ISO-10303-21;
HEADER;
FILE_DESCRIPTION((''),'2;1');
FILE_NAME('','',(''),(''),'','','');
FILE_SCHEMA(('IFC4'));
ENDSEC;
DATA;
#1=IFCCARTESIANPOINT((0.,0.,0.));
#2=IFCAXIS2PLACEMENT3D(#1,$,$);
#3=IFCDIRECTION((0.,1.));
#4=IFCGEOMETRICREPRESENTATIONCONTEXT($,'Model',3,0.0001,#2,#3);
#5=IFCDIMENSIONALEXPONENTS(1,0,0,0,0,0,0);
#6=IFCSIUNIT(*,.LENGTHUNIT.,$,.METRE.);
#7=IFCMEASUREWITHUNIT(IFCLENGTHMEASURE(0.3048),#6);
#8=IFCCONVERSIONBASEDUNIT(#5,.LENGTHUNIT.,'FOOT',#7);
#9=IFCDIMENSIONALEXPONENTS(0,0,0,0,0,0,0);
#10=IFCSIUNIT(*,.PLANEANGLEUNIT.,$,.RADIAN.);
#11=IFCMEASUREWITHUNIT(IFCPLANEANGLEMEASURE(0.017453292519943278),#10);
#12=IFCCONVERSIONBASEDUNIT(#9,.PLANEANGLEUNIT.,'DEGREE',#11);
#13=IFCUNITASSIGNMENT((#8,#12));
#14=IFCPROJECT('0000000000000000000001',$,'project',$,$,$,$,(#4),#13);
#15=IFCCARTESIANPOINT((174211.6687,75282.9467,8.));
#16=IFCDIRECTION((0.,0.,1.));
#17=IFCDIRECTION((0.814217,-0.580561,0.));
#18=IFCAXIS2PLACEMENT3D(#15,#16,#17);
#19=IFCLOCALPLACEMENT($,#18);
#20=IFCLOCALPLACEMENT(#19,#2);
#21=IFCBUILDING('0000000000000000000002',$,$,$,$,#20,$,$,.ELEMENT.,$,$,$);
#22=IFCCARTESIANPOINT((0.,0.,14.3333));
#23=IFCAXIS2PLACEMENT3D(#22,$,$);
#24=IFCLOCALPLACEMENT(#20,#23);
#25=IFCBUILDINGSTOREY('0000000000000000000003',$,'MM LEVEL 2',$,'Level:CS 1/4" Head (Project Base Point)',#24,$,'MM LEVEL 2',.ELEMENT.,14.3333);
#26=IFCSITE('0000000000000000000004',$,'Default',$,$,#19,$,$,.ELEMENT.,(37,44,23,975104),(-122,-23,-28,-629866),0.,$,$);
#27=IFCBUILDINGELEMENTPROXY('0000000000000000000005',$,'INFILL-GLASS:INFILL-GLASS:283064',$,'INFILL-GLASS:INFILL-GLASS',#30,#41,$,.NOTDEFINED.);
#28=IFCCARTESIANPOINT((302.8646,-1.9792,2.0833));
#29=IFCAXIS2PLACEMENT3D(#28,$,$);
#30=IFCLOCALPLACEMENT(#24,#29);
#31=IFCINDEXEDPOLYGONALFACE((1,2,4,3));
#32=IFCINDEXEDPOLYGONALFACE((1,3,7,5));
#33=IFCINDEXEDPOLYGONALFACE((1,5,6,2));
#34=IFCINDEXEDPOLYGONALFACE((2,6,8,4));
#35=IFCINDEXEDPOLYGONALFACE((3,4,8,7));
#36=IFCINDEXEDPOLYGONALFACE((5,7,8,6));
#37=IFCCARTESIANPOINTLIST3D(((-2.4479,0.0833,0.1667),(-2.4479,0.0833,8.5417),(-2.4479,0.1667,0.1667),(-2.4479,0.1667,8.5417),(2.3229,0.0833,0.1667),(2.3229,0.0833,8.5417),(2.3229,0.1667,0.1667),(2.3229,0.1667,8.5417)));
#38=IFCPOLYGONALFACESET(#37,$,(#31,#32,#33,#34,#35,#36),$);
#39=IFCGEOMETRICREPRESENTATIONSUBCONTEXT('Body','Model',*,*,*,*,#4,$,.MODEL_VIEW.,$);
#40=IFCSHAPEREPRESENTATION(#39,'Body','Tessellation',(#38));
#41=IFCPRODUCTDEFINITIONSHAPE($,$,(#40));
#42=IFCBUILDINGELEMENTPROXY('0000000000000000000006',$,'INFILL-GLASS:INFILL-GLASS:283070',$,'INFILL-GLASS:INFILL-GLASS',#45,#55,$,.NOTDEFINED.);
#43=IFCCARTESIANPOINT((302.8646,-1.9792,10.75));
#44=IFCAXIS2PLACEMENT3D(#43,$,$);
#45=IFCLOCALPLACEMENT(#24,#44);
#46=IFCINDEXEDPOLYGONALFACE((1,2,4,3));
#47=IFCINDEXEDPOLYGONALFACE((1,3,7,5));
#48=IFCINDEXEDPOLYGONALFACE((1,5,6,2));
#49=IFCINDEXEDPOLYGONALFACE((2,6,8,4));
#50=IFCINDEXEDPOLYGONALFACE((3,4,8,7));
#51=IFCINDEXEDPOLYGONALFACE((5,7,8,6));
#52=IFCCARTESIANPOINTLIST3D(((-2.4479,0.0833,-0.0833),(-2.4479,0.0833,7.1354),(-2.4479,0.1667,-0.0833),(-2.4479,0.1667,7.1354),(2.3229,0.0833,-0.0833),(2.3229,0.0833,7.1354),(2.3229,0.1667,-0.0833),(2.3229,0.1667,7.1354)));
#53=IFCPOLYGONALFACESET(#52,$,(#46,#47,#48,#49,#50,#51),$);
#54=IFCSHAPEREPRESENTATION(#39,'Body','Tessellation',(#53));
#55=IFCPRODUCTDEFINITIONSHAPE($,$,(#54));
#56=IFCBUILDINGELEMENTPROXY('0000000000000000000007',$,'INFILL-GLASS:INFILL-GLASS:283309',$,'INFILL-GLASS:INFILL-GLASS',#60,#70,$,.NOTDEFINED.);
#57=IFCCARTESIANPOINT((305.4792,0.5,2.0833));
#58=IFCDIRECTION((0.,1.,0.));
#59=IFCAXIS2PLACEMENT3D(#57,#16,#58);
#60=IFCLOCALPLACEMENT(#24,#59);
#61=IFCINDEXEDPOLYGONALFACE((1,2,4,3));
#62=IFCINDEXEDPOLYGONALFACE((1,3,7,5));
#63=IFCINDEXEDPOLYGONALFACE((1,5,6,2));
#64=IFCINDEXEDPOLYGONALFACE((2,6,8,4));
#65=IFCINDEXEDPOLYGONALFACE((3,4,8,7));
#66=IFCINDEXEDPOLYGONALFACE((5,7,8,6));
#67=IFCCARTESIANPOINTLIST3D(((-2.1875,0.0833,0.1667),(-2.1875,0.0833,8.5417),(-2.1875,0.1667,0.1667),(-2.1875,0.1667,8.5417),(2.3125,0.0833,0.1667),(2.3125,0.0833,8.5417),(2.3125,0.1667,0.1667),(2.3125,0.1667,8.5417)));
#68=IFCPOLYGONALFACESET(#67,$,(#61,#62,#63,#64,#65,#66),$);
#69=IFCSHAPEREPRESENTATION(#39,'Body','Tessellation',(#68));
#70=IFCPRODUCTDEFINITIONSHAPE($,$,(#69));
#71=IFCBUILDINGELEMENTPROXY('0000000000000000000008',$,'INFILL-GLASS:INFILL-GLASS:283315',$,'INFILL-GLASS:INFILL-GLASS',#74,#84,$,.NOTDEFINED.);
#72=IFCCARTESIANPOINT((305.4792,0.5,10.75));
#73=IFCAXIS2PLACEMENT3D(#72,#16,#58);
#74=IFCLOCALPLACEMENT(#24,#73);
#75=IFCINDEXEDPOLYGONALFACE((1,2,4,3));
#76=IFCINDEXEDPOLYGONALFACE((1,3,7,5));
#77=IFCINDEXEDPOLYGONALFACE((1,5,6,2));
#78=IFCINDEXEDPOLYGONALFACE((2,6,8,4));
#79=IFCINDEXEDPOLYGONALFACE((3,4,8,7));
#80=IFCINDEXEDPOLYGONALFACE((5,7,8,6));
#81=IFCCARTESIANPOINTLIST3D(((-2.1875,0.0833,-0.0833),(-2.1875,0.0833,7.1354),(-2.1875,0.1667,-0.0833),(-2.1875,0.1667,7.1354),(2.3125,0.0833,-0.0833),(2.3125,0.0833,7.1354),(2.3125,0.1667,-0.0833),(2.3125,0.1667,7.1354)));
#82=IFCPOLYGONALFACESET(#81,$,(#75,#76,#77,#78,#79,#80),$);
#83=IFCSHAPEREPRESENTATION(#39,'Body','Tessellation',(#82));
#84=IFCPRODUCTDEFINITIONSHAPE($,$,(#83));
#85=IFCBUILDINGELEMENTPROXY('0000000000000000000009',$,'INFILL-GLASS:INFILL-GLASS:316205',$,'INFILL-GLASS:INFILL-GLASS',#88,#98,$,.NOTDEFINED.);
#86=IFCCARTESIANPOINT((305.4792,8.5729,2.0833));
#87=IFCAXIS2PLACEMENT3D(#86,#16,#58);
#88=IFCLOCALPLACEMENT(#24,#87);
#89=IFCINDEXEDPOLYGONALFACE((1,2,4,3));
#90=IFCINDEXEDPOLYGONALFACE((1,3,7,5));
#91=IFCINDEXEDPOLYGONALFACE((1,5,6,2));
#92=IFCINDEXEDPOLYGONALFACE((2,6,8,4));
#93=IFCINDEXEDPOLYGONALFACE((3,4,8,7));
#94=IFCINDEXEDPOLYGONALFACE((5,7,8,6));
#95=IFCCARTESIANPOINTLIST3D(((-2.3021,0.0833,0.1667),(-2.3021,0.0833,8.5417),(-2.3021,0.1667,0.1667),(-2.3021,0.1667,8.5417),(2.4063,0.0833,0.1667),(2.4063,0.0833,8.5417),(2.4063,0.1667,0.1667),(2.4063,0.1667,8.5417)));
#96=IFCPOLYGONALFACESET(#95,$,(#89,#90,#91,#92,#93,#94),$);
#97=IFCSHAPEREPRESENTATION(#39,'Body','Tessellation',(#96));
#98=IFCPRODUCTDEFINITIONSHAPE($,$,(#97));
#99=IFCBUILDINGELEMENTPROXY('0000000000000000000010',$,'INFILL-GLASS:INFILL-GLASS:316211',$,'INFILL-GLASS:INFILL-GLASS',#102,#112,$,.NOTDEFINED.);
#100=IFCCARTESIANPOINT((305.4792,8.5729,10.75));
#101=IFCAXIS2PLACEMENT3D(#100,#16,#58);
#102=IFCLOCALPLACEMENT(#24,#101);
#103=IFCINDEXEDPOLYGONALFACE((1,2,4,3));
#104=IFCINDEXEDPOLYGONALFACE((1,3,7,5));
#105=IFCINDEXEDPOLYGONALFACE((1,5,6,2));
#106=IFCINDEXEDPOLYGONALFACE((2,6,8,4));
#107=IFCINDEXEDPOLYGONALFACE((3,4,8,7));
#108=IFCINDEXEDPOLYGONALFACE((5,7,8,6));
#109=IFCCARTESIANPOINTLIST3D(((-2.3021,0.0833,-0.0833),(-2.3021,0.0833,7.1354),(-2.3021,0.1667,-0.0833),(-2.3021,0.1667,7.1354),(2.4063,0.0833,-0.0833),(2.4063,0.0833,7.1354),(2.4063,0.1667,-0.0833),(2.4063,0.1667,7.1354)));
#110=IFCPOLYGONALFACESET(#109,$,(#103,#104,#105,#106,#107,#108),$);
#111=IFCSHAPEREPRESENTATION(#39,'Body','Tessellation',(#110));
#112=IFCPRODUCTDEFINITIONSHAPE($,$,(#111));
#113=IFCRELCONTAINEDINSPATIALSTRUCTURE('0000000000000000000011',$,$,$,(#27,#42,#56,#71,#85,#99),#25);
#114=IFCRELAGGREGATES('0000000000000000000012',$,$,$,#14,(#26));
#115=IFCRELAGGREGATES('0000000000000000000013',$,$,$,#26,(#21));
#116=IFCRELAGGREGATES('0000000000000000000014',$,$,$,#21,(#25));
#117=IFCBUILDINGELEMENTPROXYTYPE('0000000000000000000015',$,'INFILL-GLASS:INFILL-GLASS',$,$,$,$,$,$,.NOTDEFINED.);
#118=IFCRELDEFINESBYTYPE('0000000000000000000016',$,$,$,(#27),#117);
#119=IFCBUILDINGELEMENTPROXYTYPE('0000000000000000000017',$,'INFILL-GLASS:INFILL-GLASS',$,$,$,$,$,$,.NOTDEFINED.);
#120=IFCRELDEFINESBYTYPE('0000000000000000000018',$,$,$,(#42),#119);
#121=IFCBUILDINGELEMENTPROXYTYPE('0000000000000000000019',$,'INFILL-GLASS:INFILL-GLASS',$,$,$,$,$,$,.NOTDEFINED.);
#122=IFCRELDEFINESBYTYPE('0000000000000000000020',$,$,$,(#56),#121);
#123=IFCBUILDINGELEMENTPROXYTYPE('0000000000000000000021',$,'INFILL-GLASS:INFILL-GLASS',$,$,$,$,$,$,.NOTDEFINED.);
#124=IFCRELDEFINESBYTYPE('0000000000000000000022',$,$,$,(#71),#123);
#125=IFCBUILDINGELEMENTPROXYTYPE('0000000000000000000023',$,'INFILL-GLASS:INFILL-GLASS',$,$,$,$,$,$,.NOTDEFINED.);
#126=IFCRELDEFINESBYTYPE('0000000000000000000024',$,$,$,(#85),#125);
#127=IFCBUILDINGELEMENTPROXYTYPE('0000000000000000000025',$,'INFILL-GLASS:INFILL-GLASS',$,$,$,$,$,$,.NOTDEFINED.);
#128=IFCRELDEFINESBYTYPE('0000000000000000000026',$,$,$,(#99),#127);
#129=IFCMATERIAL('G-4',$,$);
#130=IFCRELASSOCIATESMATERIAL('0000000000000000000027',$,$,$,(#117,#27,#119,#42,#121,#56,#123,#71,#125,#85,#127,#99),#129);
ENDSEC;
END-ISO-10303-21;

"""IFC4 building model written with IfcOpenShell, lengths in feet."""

from ifc_helpers import new_model, entity, si_unit, converted_unit, direction, frame, origin, place, context, subcontext, project, spatial, indexed_curve, outline, extrude, source, transform, mapped, material, type_object, type_shapes, element, save


model = new_model("IFC4")

# Units and contexts
model_context = context("Model", 3, precision=0.0001, world=origin(), true_north=direction((0.0, 1.0)))
body_context = subcontext(model_context, "Body", "Model", "MODEL_VIEW")
ifc_project = project(units=[converted_unit("LENGTHUNIT", "FOOT", entity("IfcLengthMeasure", 0.3048), si_unit("LENGTHUNIT", "METRE"), dimensions=[1, 0, 0, 0, 0, 0, 0]), converted_unit("PLANEANGLEUNIT", "DEGREE", entity("IfcPlaneAngleMeasure", 0.017453292519943278), si_unit("PLANEANGLEUNIT", "RADIAN"), dimensions=[0, 0, 0, 0, 0, 0, 0])], contexts=[model_context])

# Site, building, storey
site_placement = place(None, frame((174211.6687, 75282.9467, 8.0), z_axis=(0.0, 0.0, 1.0), x_axis=(0.814217, -0.580561, 0.0)))
site = spatial("IfcSite", under=ifc_project, at=site_placement, Name="Default", CompositionType="ELEMENT", RefLatitude=(37, 44, 23, 975104), RefLongitude=(-122, -23, -28, -629866), RefElevation=0.0)
building_placement = place(site_placement, origin())
building = spatial("IfcBuilding", under=site, at=building_placement, CompositionType="ELEMENT")
storey_placement = place(building_placement, frame((0.0, 0.0, 14.3333)))
storey = spatial("IfcBuildingStorey", under=building, at=storey_placement, Name="MM LEVEL 2", ObjectType="Level:CS 1/4\" Head (Project Base Point)", LongName="MM LEVEL 2", CompositionType="ELEMENT", Elevation=14.3333)

# Building element proxies
ifc_material_1 = material(Name="G-4")
building_element_proxy_type_1 = type_object("IfcBuildingElementProxyType", Name="INFILL-GLASS:INFILL-GLASS", PredefinedType="NOTDEFINED", material=ifc_material_1)
shared_shape_1 = source(origin(), body_context, "Body", "SweptSolid", [
    extrude(outline(indexed_curve([(-0.0417, -2.3854), (0.0417, -2.3854), (0.0417, 2.3854), (-0.0417, 2.3854), (-0.0417, -2.3854)], self_intersect=False)), frame((-0.0625, 0.125, 0.1667), z_axis=(0.0, 0.0, 1.0), x_axis=(0.0, 1.0, 0.0)), (0.0, 0.0, 1.0), 8.375),
])
type_shapes(building_element_proxy_type_1, [shared_shape_1])
proxy_1_placement = place(storey_placement, frame((302.8646, -1.9792, 2.0833)))
element("IfcBuildingElementProxy", 1, at=proxy_1_placement, inside=storey, type_object=building_element_proxy_type_1, material=ifc_material_1, Name="INFILL-GLASS:INFILL-GLASS:283064", ObjectType="INFILL-GLASS:INFILL-GLASS", PredefinedType="NOTDEFINED", context=body_context, shape_type="MappedRepresentation", body=[
    mapped(shared_shape_1, transform((0.0, 0.0, 0.0), scale=1.0)),
])
building_element_proxy_type_2 = type_object("IfcBuildingElementProxyType", Name="INFILL-GLASS:INFILL-GLASS", PredefinedType="NOTDEFINED", material=ifc_material_1)
shared_shape_2 = source(origin(), body_context, "Body", "SweptSolid", [
    extrude(outline(indexed_curve([(-0.0417, -2.3854), (0.0417, -2.3854), (0.0417, 2.3854), (-0.0417, 2.3854), (-0.0417, -2.3854)], self_intersect=False)), frame((-0.0625, 0.125, -0.0833), z_axis=(0.0, 0.0, 1.0), x_axis=(0.0, 1.0, 0.0)), (0.0, 0.0, 1.0), 7.2187),
])
type_shapes(building_element_proxy_type_2, [shared_shape_2])
proxy_2_placement = place(storey_placement, frame((302.8646, -1.9792, 10.75)))
element("IfcBuildingElementProxy", 2, at=proxy_2_placement, inside=storey, type_object=building_element_proxy_type_2, material=ifc_material_1, Name="INFILL-GLASS:INFILL-GLASS:283070", ObjectType="INFILL-GLASS:INFILL-GLASS", PredefinedType="NOTDEFINED", context=body_context, shape_type="MappedRepresentation", body=[
    mapped(shared_shape_2, transform((0.0, 0.0, 0.0), scale=1.0)),
])
building_element_proxy_type_3 = type_object("IfcBuildingElementProxyType", Name="INFILL-GLASS:INFILL-GLASS", PredefinedType="NOTDEFINED", material=ifc_material_1)
shared_shape_3 = source(origin(), body_context, "Body", "SweptSolid", [
    extrude(outline(indexed_curve([(-0.0417, -2.25), (0.0417, -2.25), (0.0417, 2.25), (-0.0417, 2.25), (-0.0417, -2.25)], self_intersect=False)), frame((0.0625, 0.125, 0.1667), z_axis=(0.0, 0.0, 1.0), x_axis=(0.0, 1.0, 0.0)), (0.0, 0.0, 1.0), 8.375),
])
type_shapes(building_element_proxy_type_3, [shared_shape_3])
proxy_3_placement = place(storey_placement, frame((305.4792, 0.5, 2.0833), z_axis=(0.0, 0.0, 1.0), x_axis=(0.0, 1.0, 0.0)))
element("IfcBuildingElementProxy", 3, at=proxy_3_placement, inside=storey, type_object=building_element_proxy_type_3, material=ifc_material_1, Name="INFILL-GLASS:INFILL-GLASS:283309", ObjectType="INFILL-GLASS:INFILL-GLASS", PredefinedType="NOTDEFINED", context=body_context, shape_type="MappedRepresentation", body=[
    mapped(shared_shape_3, transform((0.0, 0.0, 0.0), scale=1.0)),
])
building_element_proxy_type_4 = type_object("IfcBuildingElementProxyType", Name="INFILL-GLASS:INFILL-GLASS", PredefinedType="NOTDEFINED", material=ifc_material_1)
shared_shape_4 = source(origin(), body_context, "Body", "SweptSolid", [
    extrude(outline(indexed_curve([(-0.0417, -2.25), (0.0417, -2.25), (0.0417, 2.25), (-0.0417, 2.25), (-0.0417, -2.25)], self_intersect=False)), frame((0.0625, 0.125, -0.0833), z_axis=(0.0, 0.0, 1.0), x_axis=(0.0, 1.0, 0.0)), (0.0, 0.0, 1.0), 7.2187),
])
type_shapes(building_element_proxy_type_4, [shared_shape_4])
proxy_4_placement = place(storey_placement, frame((305.4792, 0.5, 10.75), z_axis=(0.0, 0.0, 1.0), x_axis=(0.0, 1.0, 0.0)))
element("IfcBuildingElementProxy", 4, at=proxy_4_placement, inside=storey, type_object=building_element_proxy_type_4, material=ifc_material_1, Name="INFILL-GLASS:INFILL-GLASS:283315", ObjectType="INFILL-GLASS:INFILL-GLASS", PredefinedType="NOTDEFINED", context=body_context, shape_type="MappedRepresentation", body=[
    mapped(shared_shape_4, transform((0.0, 0.0, 0.0), scale=1.0)),
])
building_element_proxy_type_5 = type_object("IfcBuildingElementProxyType", Name="INFILL-GLASS:INFILL-GLASS", PredefinedType="NOTDEFINED", material=ifc_material_1)
shared_shape_5 = source(origin(), body_context, "Body", "SweptSolid", [
    extrude(outline(indexed_curve([(-0.0417, -2.3542), (0.0417, -2.3542), (0.0417, 2.3542), (-0.0417, 2.3542), (-0.0417, -2.3542)], self_intersect=False)), frame((0.0521, 0.125, 0.1667), z_axis=(0.0, 0.0, 1.0), x_axis=(0.0, 1.0, 0.0)), (0.0, 0.0, 1.0), 8.375),
])
type_shapes(building_element_proxy_type_5, [shared_shape_5])
proxy_5_placement = place(storey_placement, frame((305.4792, 8.5729, 2.0833), z_axis=(0.0, 0.0, 1.0), x_axis=(0.0, 1.0, 0.0)))
element("IfcBuildingElementProxy", 5, at=proxy_5_placement, inside=storey, type_object=building_element_proxy_type_5, material=ifc_material_1, Name="INFILL-GLASS:INFILL-GLASS:316205", ObjectType="INFILL-GLASS:INFILL-GLASS", PredefinedType="NOTDEFINED", context=body_context, shape_type="MappedRepresentation", body=[
    mapped(shared_shape_5, transform((0.0, 0.0, 0.0), scale=1.0)),
])
building_element_proxy_type_6 = type_object("IfcBuildingElementProxyType", Name="INFILL-GLASS:INFILL-GLASS", PredefinedType="NOTDEFINED", material=ifc_material_1)
shared_shape_6 = source(origin(), body_context, "Body", "SweptSolid", [
    extrude(outline(indexed_curve([(-0.0417, -2.3542), (0.0417, -2.3542), (0.0417, 2.3542), (-0.0417, 2.3542), (-0.0417, -2.3542)], self_intersect=False)), frame((0.0521, 0.125, -0.0833), z_axis=(0.0, 0.0, 1.0), x_axis=(0.0, 1.0, 0.0)), (0.0, 0.0, 1.0), 7.2187),
])
type_shapes(building_element_proxy_type_6, [shared_shape_6])
proxy_6_placement = place(storey_placement, frame((305.4792, 8.5729, 10.75), z_axis=(0.0, 0.0, 1.0), x_axis=(0.0, 1.0, 0.0)))
element("IfcBuildingElementProxy", 6, at=proxy_6_placement, inside=storey, type_object=building_element_proxy_type_6, material=ifc_material_1, Name="INFILL-GLASS:INFILL-GLASS:316211", ObjectType="INFILL-GLASS:INFILL-GLASS", PredefinedType="NOTDEFINED", context=body_context, shape_type="MappedRepresentation", body=[
    mapped(shared_shape_6, transform((0.0, 0.0, 0.0), scale=1.0)),
])

save(model, "model.ifc")
